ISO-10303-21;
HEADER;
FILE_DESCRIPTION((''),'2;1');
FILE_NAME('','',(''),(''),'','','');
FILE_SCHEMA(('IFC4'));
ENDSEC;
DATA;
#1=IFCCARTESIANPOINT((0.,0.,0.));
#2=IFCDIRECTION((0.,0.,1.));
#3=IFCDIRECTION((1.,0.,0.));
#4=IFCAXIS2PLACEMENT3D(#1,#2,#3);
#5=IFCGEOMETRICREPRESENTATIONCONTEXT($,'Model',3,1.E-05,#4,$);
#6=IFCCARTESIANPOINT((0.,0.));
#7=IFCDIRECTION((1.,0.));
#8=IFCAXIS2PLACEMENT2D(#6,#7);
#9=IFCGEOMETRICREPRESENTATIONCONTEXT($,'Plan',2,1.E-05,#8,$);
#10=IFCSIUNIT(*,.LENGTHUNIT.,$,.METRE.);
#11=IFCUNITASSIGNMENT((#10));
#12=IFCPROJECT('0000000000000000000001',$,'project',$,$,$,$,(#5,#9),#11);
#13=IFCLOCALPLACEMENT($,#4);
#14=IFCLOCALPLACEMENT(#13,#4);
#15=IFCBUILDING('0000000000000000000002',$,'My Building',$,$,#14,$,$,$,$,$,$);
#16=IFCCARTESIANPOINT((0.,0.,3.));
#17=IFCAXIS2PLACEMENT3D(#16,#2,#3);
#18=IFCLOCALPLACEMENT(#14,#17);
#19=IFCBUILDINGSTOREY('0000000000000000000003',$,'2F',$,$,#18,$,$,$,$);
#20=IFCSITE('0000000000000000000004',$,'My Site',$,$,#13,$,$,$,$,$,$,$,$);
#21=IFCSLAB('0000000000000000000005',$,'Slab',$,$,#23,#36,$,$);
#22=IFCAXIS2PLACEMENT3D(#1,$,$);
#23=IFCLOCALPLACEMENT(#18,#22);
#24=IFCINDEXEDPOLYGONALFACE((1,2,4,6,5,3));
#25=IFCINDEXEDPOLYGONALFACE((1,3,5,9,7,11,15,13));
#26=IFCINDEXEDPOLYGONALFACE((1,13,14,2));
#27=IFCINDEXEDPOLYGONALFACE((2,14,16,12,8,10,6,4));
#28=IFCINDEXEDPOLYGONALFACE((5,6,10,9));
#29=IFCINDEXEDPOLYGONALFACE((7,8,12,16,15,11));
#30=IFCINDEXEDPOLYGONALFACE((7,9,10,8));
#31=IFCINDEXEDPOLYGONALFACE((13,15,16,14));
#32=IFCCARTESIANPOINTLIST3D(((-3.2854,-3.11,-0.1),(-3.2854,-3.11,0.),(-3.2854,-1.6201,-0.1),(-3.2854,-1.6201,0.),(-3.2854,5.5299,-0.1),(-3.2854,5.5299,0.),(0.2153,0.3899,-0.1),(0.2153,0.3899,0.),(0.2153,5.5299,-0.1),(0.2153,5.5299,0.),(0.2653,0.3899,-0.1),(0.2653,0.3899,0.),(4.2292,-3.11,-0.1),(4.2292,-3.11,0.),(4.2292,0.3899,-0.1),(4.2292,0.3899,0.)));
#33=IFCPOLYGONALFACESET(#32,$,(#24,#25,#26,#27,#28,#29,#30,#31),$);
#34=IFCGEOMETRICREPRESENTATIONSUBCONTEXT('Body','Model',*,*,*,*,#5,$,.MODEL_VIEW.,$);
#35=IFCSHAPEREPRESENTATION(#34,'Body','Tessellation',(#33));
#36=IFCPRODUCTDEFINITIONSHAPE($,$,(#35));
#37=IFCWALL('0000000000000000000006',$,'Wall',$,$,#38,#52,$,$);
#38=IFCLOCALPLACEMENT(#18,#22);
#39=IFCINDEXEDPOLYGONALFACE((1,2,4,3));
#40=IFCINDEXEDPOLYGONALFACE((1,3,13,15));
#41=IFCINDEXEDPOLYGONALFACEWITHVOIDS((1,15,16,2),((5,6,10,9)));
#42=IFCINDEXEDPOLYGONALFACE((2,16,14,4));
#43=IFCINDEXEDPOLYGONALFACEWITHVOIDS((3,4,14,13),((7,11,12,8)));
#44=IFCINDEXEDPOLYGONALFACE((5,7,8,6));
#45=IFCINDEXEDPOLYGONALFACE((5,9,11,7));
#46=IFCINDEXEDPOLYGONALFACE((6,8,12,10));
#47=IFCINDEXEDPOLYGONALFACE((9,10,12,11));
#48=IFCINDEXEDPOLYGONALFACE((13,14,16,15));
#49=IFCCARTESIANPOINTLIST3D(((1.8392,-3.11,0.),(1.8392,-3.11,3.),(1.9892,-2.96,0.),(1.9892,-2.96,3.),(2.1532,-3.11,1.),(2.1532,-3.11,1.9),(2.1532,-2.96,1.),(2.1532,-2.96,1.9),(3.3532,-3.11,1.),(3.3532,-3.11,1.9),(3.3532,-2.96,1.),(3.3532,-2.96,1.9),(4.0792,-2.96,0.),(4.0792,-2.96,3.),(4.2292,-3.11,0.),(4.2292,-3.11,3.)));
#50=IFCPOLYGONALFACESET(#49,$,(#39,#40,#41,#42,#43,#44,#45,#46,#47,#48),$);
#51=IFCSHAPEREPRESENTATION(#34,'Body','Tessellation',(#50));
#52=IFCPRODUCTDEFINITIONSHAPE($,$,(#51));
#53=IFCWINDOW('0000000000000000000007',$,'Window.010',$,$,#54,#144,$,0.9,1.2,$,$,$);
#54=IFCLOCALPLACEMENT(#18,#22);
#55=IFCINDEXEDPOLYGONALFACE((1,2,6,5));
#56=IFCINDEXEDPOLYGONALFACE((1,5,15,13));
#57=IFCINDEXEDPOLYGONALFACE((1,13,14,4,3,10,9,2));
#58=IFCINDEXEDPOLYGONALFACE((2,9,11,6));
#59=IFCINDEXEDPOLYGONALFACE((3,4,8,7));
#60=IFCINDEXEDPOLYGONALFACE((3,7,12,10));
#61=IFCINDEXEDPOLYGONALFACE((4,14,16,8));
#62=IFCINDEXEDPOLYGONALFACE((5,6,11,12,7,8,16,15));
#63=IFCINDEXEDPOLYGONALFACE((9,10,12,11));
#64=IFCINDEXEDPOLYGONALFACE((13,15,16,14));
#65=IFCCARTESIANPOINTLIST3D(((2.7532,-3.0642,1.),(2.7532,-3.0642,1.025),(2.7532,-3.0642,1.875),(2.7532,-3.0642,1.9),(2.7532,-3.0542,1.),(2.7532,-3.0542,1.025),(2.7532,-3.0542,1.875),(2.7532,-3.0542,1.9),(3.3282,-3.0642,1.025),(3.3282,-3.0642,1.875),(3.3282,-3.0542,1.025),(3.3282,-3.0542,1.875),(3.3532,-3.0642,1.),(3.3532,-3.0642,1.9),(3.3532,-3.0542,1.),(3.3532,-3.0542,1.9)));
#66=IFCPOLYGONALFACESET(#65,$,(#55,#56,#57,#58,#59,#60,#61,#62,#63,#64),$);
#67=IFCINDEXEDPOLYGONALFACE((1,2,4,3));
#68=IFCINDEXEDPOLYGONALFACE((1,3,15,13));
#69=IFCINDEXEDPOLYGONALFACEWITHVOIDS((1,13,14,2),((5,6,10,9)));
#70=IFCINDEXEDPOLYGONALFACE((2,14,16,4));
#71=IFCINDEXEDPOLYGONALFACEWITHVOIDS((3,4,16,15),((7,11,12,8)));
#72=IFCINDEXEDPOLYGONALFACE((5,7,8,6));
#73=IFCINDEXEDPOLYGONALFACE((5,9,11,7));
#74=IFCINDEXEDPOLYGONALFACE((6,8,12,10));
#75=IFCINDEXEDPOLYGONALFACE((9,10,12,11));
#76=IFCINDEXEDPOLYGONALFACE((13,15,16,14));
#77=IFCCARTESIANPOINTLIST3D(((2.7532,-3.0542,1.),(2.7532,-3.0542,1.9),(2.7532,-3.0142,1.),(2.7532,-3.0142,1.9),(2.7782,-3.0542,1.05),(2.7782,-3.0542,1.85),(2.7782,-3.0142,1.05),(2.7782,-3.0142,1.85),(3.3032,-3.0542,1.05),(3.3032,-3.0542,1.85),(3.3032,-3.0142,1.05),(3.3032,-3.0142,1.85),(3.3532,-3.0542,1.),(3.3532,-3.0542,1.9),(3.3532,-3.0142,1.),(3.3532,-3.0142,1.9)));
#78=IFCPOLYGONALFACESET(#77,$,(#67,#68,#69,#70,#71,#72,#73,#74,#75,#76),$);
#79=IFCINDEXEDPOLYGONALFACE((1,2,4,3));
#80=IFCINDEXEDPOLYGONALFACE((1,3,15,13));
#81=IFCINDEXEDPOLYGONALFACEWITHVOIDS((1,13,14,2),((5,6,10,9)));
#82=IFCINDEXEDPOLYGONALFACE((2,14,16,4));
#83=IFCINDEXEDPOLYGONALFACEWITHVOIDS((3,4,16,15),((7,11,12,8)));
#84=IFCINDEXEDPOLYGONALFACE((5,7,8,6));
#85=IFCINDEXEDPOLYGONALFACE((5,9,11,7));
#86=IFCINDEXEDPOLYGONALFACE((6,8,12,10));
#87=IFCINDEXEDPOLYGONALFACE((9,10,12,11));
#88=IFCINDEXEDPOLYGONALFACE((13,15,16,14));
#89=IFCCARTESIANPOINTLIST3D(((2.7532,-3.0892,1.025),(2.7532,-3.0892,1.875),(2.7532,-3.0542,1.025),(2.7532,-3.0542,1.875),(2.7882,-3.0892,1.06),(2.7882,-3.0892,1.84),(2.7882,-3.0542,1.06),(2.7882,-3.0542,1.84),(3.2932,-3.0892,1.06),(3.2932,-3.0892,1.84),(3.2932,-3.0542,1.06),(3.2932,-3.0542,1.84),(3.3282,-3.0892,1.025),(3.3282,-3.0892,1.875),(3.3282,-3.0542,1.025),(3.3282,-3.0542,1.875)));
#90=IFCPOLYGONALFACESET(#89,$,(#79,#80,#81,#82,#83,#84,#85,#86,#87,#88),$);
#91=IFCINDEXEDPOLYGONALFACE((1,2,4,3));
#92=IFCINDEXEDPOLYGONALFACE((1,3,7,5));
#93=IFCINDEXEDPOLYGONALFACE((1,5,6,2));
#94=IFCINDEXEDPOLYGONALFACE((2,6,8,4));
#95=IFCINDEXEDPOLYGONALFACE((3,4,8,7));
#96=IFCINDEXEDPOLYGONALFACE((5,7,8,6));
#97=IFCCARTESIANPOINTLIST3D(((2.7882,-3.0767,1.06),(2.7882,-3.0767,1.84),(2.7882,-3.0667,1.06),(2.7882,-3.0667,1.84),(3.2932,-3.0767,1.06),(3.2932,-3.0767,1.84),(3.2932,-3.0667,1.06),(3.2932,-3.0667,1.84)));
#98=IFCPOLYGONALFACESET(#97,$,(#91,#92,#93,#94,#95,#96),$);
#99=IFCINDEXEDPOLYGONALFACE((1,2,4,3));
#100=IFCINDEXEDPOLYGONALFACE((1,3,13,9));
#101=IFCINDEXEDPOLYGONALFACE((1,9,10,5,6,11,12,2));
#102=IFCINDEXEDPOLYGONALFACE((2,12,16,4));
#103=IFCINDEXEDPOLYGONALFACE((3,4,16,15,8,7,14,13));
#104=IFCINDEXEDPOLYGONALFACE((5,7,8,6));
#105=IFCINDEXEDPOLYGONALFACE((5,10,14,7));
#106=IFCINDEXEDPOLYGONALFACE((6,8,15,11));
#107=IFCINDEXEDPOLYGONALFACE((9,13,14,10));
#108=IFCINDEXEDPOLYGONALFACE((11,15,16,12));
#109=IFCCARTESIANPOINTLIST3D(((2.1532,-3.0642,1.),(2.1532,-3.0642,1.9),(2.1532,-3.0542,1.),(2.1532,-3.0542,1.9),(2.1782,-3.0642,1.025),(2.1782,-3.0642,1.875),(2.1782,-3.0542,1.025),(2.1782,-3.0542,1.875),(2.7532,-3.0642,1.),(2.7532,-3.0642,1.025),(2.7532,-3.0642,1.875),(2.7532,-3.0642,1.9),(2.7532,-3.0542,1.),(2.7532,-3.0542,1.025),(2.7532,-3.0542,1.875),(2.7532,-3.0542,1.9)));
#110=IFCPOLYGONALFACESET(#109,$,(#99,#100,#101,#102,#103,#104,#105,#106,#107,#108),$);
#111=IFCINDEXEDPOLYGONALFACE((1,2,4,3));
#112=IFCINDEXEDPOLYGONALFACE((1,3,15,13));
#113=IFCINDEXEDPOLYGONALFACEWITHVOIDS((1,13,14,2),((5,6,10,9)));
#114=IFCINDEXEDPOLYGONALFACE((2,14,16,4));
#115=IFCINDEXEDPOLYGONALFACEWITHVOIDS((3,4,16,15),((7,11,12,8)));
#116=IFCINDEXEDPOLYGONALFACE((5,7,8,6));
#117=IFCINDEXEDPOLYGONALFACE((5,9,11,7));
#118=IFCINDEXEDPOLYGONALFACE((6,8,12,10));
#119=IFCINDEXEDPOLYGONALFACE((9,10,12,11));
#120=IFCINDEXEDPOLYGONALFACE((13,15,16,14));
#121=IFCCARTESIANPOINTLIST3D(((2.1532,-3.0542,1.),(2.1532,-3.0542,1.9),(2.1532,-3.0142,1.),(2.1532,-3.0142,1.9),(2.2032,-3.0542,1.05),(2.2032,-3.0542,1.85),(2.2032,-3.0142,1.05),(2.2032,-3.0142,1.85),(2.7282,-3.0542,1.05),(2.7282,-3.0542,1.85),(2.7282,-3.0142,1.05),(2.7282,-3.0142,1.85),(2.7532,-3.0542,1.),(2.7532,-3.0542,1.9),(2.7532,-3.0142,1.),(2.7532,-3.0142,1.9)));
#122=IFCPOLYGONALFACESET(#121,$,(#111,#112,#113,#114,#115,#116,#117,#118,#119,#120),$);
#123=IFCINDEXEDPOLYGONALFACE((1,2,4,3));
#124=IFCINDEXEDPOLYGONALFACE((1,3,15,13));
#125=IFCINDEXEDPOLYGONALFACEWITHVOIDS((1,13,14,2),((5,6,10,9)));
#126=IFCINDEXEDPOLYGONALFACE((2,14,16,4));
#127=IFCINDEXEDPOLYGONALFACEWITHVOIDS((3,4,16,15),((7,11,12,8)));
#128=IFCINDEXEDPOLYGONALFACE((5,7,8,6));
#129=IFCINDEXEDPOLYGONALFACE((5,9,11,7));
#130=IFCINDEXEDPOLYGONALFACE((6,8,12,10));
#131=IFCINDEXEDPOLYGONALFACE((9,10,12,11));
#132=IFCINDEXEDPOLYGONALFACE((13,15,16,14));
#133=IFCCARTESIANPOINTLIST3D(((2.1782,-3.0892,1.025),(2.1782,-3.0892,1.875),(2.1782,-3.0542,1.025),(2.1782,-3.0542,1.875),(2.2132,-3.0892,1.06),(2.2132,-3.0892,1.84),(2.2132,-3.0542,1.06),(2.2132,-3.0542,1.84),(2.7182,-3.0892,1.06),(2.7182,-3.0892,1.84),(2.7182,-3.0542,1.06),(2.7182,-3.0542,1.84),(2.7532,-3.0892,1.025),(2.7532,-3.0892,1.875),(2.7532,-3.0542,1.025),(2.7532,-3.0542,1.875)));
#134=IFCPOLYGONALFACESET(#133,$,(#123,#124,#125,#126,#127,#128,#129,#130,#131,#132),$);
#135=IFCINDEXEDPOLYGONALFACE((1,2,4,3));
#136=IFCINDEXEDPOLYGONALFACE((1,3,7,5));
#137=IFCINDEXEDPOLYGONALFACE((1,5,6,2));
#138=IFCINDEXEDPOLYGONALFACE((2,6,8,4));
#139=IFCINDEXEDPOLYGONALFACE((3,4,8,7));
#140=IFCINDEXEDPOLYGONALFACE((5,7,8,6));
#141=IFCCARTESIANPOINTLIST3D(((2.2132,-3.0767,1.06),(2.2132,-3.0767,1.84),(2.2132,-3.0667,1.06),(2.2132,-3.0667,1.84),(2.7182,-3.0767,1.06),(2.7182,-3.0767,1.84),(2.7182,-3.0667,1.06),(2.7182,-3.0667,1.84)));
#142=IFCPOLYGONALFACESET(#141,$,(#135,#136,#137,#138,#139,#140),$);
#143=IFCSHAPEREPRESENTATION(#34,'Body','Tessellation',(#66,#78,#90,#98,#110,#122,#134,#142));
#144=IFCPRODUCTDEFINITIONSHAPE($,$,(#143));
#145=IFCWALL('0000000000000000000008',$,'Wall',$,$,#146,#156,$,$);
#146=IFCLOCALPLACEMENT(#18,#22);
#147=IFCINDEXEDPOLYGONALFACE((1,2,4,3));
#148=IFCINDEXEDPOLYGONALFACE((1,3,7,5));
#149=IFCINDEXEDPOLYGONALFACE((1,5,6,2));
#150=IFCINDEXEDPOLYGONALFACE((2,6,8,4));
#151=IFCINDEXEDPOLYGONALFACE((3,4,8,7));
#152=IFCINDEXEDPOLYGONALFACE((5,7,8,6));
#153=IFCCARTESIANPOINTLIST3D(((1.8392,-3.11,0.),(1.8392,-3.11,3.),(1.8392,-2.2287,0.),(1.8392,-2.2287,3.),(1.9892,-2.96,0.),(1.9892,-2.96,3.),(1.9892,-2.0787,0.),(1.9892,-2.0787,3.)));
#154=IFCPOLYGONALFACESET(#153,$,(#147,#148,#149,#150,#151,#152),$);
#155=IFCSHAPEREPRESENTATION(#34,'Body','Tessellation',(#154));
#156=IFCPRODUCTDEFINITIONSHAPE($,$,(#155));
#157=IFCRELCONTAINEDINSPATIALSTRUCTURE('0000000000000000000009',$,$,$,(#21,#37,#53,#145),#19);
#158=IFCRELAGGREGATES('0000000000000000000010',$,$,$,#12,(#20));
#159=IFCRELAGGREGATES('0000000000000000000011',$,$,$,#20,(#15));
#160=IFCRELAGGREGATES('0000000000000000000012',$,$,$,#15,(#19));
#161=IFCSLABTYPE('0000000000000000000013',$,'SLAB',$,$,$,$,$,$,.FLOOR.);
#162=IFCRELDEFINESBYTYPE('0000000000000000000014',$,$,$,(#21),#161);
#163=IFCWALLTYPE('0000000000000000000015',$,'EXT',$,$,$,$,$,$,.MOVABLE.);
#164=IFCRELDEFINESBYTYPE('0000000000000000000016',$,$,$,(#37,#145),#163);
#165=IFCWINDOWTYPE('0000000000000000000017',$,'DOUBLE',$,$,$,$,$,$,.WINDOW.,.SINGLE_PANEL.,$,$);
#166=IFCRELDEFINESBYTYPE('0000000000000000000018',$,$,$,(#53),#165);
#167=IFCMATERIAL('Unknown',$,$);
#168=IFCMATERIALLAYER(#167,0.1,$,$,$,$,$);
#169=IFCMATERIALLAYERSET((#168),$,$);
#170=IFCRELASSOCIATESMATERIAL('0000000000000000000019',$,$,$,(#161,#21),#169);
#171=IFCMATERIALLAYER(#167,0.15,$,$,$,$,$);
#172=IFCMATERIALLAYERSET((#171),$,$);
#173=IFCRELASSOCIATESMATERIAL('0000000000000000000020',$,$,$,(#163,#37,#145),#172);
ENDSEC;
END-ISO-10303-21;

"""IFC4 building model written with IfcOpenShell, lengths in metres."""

from ifc_helpers import new_model, entity, si_unit, frame, origin_with_axes, origin_2d_with_axis, place, context, subcontext, project, spatial, line, indexed_curve, outline, extrude, shape, source, transform, mapped, material, layer, layer_set, layer_usage, type_object, type_shapes, element, fill, save


model = new_model("IFC4")

# Units and contexts
model_context = context("Model", 3, precision=1e-05, world=origin_with_axes())
plan_context = context("Plan", 2, precision=1e-05, world=origin_2d_with_axis())
body_context_1 = subcontext(model_context, "Body", "Model", "MODEL_VIEW")
body_context_2 = subcontext(plan_context, "Body", "Plan", "PLAN_VIEW")
ifc_project = project(units=[si_unit("LENGTHUNIT", "METRE")], contexts=[model_context, plan_context])

# Site, building, storey
site_placement = place(None, origin_with_axes())
site = spatial("IfcSite", under=ifc_project, at=site_placement, Name="My Site")
building_placement = place(site_placement, origin_with_axes())
building = spatial("IfcBuilding", under=site, at=building_placement, Name="My Building")
storey_placement = place(building_placement, frame((0.0, 0.0, 3.0), z_axis=(0.0, 0.0, 1.0), x_axis=(1.0, 0.0, 0.0)))
storey = spatial("IfcBuildingStorey", under=building, at=storey_placement, Name="2F")

# Slab
ifc_material = material(Name="Unknown")
ifc_layer_1 = layer(ifc_material, 0.1)
ifc_layer_set_1 = layer_set([ifc_layer_1])
ifc_layer_usage_1 = layer_usage(ifc_layer_set_1, "AXIS3", "POSITIVE", -0.1)
slab_type = type_object("IfcSlabType", Name="SLAB", PredefinedType="FLOOR", material=ifc_layer_set_1)
slab_placement = place(storey_placement, frame((-3.2854, -1.6201, 0.0), z_axis=(0.0, 0.0, 1.0), x_axis=(1.0, 0.0, 0.0)))
element("IfcSlab", 1, at=slab_placement, inside=storey, type_object=slab_type, material=ifc_layer_usage_1, Name="Slab", context=body_context_1, shape_type="SweptSolid", body=[
    extrude(outline(indexed_curve([(0.0, 0.0), (0.0, -1.4899), (7.5146, -1.4899), (7.5146, 2.01), (3.5507, 2.01), (3.5007, 2.01), (3.5007, 7.15), (0.0, 7.15), (0.0, 0.0)])), frame((0.0, 0.0, -0.1), z_axis=(0.0, 0.0, 1.0), x_axis=(1.0, 0.0, 0.0)), (0.0, 0.0, 1.0), 0.1),
])

# Wall, opening, window
ifc_layer_2 = layer(ifc_material, 0.15)
ifc_layer_set_2 = layer_set([ifc_layer_2])
ifc_layer_usage_2 = layer_usage(ifc_layer_set_2, "AXIS2", "POSITIVE", -0.15)
wall_type = type_object("IfcWallType", Name="EXT", PredefinedType="MOVABLE", material=ifc_layer_set_2)
wall_1_placement = place(storey_placement, frame((4.2292, -3.11, 0.0), z_axis=(0.0, 0.0, 1.0), x_axis=(-1.0, 0.0, 0.0)))
wall_1 = element("IfcWall", 2, at=wall_1_placement, inside=storey, type_object=wall_type, material=ifc_layer_usage_2, Name="Wall", context=body_context_1, shape_type="SweptSolid", body=[
    extrude(outline(indexed_curve([(0.15, -0.15), (0.0, 0.0), (2.39, 0.0), (2.24, -0.15)], segments=[line(1, 2, 3, 4, 1)])), origin_with_axes(), (0.0, 0.0, 1.0), 3.0),
])
placement_1 = place(storey_placement, frame((3.3532, -2.9642, 1.0), z_axis=(0.0, 0.0, 1.0), x_axis=(-1.0, 0.000001, 0.0)))
opening_1 = element("IfcOpeningElement", 3, at=placement_1, cuts=wall_1, PredefinedType="OPENING", context=body_context_1, shape_type="SweptSolid", body=[
    extrude(outline(indexed_curve([(0.0, 0.0), (1.2, 0.0), (1.2, 0.9), (0.0, 0.9)], segments=[line(1, 2, 3, 4, 1)])), frame((0.0, -0.6, 0.0), z_axis=(0.0, -1.0, 0.0), x_axis=(1.0, 0.0, 0.0)), (0.0, 0.0, -1.0), 1.2),
])
window_type_1 = type_object("IfcWindowType", Name="DOUBLE", PartitioningType="SINGLE_PANEL", PredefinedType="WINDOW")
shared_shape_1 = source(origin_with_axes(), body_context_1, "Body", "SweptSolid", [
    extrude(outline(indexed_curve([(0.6, 0.0), (0.0, 0.0), (0.0, 0.9), (0.6, 0.9), (0.6, 0.875), (0.025, 0.875), (0.025, 0.025), (0.6, 0.025)], segments=[line(1, 2, 3, 4, 5, 6, 7, 8, 1)])), frame((0.0, 0.09, 0.0), z_axis=(0.0, -1.0, 0.0), x_axis=(1.0, 0.0, 0.0)), (0.0, 0.0, -1.0), 0.01),
    extrude(outline(indexed_curve([(0.0, 0.0), (0.6, 0.0), (0.6, 0.9), (0.0, 0.9)], segments=[line(1, 2, 3, 4, 1)]), holes=[indexed_curve([(0.05, 0.05), (0.575, 0.05), (0.575, 0.85), (0.05, 0.85)], segments=[line(1, 2, 3, 4, 1)])]), frame((0.0, 0.05, 0.0), z_axis=(0.0, -1.0, 0.0), x_axis=(1.0, 0.0, 0.0)), (0.0, 0.0, -1.0), 0.04),
    extrude(outline(indexed_curve([(0.0, 0.0), (0.575, 0.0), (0.575, 0.85), (0.0, 0.85)], segments=[line(1, 2, 3, 4, 1)]), holes=[indexed_curve([(0.035, 0.035), (0.54, 0.035), (0.54, 0.815), (0.035, 0.815)], segments=[line(1, 2, 3, 4, 1)])]), frame((0.025, 0.09, 0.025), z_axis=(0.0, -1.0, 0.0), x_axis=(1.0, 0.0, 0.0)), (0.0, 0.0, -1.0), 0.035),
    extrude(outline(indexed_curve([(0.035, 0.035), (0.54, 0.035), (0.54, 0.815), (0.035, 0.815)], segments=[line(1, 2, 3, 4, 1)])), frame((0.025, 0.1025, 0.025), z_axis=(0.0, -1.0, 0.0), x_axis=(1.0, 0.0, 0.0)), (0.0, 0.0, -1.0), 0.01),
    extrude(outline(indexed_curve([(0.0, 0.9), (0.6, 0.9), (0.6, 0.0), (0.0, 0.0), (0.0, 0.025), (0.575, 0.025), (0.575, 0.875), (0.0, 0.875)], segments=[line(1, 2, 3, 4, 5, 6, 7, 8, 1)])), frame((0.6, 0.09, 0.0), z_axis=(0.0, -1.0, 0.0), x_axis=(1.0, 0.0, 0.0)), (0.0, 0.0, -1.0), 0.01),
    extrude(outline(indexed_curve([(0.0, 0.0), (0.6, 0.0), (0.6, 0.9), (0.0, 0.9)], segments=[line(1, 2, 3, 4, 1)]), holes=[indexed_curve([(0.025, 0.05), (0.55, 0.05), (0.55, 0.85), (0.025, 0.85)], segments=[line(1, 2, 3, 4, 1)])]), frame((0.6, 0.05, 0.0), z_axis=(0.0, -1.0, 0.0), x_axis=(1.0, 0.0, 0.0)), (0.0, 0.0, -1.0), 0.04),
    extrude(outline(indexed_curve([(0.0, 0.0), (0.575, 0.0), (0.575, 0.85), (0.0, 0.85)], segments=[line(1, 2, 3, 4, 1)]), holes=[indexed_curve([(0.035, 0.035), (0.54, 0.035), (0.54, 0.815), (0.035, 0.815)], segments=[line(1, 2, 3, 4, 1)])]), frame((0.6, 0.09, 0.025), z_axis=(0.0, -1.0, 0.0), x_axis=(1.0, 0.0, 0.0)), (0.0, 0.0, -1.0), 0.035),
    extrude(outline(indexed_curve([(0.035, 0.815), (0.54, 0.815), (0.54, 0.035), (0.035, 0.035), (0.035, 0.815)])), frame((0.6, 0.1025, 0.025), z_axis=(0.0, -1.0, 0.0), x_axis=(1.0, 0.0, 0.0)), (0.0, 0.0, -1.0), 0.01),
])
shared_shape_2 = source(origin_with_axes(), body_context_2, "Body", "Curve2D", [
    entity("IfcIndexedPolyCurve", entity("IfcCartesianPointList2D", [[0.05, 0.05], [0.575, 0.05]])),
    entity("IfcIndexedPolyCurve", entity("IfcCartesianPointList2D", [[0.0, 0.1], [0.025, 0.1], [0.025, 0.09], [0.05, 0.09], [0.05, 0.05], [0.0, 0.05]]), [entity("IfcLineIndex", [1, 2, 3, 4, 5, 6, 1])]),
    entity("IfcIndexedPolyCurve", entity("IfcCartesianPointList2D", [[0.6, 0.1], [0.6, 0.1], [0.6, 0.09], [0.575, 0.09], [0.575, 0.05], [0.6, 0.05]])),
    entity("IfcIndexedPolyCurve", entity("IfcCartesianPointList2D", [[0.025, 0.09], [0.06, 0.09], [0.06, 0.125], [0.025, 0.125]]), [entity("IfcLineIndex", [1, 2, 3, 4, 1])]),
    entity("IfcIndexedPolyCurve", entity("IfcCartesianPointList2D", [[0.6, 0.09], [0.565, 0.09], [0.565, 0.125], [0.6, 0.125]]), [entity("IfcLineIndex", [1, 2, 3, 4, 1])]),
    entity("IfcIndexedPolyCurve", entity("IfcCartesianPointList2D", [[0.06, 0.09], [0.565, 0.09]])),
    entity("IfcIndexedPolyCurve", entity("IfcCartesianPointList2D", [[0.06, 0.125], [0.565, 0.125]])),
    entity("IfcIndexedPolyCurve", entity("IfcCartesianPointList2D", [[0.06, 0.1075], [0.565, 0.1075]])),
    entity("IfcIndexedPolyCurve", entity("IfcCartesianPointList2D", [[0.625, 0.05], [1.15, 0.05]])),
    entity("IfcIndexedPolyCurve", entity("IfcCartesianPointList2D", [[0.6, 0.1], [0.6, 0.1], [0.6, 0.09], [0.625, 0.09], [0.625, 0.05], [0.6, 0.05]])),
    entity("IfcIndexedPolyCurve", entity("IfcCartesianPointList2D", [[1.2, 0.1], [1.175, 0.1], [1.175, 0.09], [1.15, 0.09], [1.15, 0.05], [1.2, 0.05]]), [entity("IfcLineIndex", [1, 2, 3, 4, 5, 6, 1])]),
    entity("IfcIndexedPolyCurve", entity("IfcCartesianPointList2D", [[0.6, 0.09], [0.635, 0.09], [0.635, 0.125], [0.6, 0.125]]), [entity("IfcLineIndex", [1, 2, 3, 4, 1])]),
    entity("IfcIndexedPolyCurve", entity("IfcCartesianPointList2D", [[1.175, 0.09], [1.14, 0.09], [1.14, 0.125], [1.175, 0.125]]), [entity("IfcLineIndex", [1, 2, 3, 4, 1])]),
    entity("IfcIndexedPolyCurve", entity("IfcCartesianPointList2D", [[0.635, 0.09], [1.14, 0.09]])),
    entity("IfcIndexedPolyCurve", entity("IfcCartesianPointList2D", [[0.635, 0.125], [1.14, 0.125]])),
    entity("IfcIndexedPolyCurve", entity("IfcCartesianPointList2D", [[0.635, 0.1075], [1.14, 0.1075]])),
])
type_shapes(window_type_1, [shared_shape_1, shared_shape_2])
window_1 = element("IfcWindow", 4, at=placement_1, inside=storey, type_object=window_type_1, Name="Window.010", OverallHeight=0.9, OverallWidth=1.2, shapes=[
    shape(body_context_1, "Body", "MappedRepresentation", [mapped(shared_shape_1, transform((0.0, 0.0, 0.0), x_axis=(1.0, 0.0, 0.0), y_axis=(0.0, 1.0, 0.0), z_axis=(0.0, 0.0, 1.0), scale=1.0))]),
    shape(body_context_2, "Body", "MappedRepresentation", [mapped(shared_shape_2, transform((0.0, 0.0, 0.0), x_axis=(1.0, 0.0, 0.0), y_axis=(0.0, 1.0, 0.0), z_axis=(0.0, 0.0, 1.0), scale=1.0))]),
])
fill(opening_1, window_1)

# Wall
ifc_layer_usage_3 = layer_usage(ifc_layer_set_2, "AXIS2", "POSITIVE", -0.15)
wall_2_placement = place(storey_placement, frame((1.8392, -3.11, 0.0), z_axis=(0.0, 0.0, 1.0), x_axis=(0.0, 1.0, 0.0)))
element("IfcWall", 5, at=wall_2_placement, inside=storey, type_object=wall_type, material=ifc_layer_usage_3, Name="Wall", context=body_context_1, shape_type="SweptSolid", body=[
    extrude(outline(indexed_curve([(0.15, -0.15), (0.0, 0.0), (0.8813, 0.0), (1.0313, -0.15)], segments=[line(1, 2, 3, 4, 1)])), origin_with_axes(), (0.0, 0.0, 1.0), 3.0),
])

save(model, "model.ifc")
